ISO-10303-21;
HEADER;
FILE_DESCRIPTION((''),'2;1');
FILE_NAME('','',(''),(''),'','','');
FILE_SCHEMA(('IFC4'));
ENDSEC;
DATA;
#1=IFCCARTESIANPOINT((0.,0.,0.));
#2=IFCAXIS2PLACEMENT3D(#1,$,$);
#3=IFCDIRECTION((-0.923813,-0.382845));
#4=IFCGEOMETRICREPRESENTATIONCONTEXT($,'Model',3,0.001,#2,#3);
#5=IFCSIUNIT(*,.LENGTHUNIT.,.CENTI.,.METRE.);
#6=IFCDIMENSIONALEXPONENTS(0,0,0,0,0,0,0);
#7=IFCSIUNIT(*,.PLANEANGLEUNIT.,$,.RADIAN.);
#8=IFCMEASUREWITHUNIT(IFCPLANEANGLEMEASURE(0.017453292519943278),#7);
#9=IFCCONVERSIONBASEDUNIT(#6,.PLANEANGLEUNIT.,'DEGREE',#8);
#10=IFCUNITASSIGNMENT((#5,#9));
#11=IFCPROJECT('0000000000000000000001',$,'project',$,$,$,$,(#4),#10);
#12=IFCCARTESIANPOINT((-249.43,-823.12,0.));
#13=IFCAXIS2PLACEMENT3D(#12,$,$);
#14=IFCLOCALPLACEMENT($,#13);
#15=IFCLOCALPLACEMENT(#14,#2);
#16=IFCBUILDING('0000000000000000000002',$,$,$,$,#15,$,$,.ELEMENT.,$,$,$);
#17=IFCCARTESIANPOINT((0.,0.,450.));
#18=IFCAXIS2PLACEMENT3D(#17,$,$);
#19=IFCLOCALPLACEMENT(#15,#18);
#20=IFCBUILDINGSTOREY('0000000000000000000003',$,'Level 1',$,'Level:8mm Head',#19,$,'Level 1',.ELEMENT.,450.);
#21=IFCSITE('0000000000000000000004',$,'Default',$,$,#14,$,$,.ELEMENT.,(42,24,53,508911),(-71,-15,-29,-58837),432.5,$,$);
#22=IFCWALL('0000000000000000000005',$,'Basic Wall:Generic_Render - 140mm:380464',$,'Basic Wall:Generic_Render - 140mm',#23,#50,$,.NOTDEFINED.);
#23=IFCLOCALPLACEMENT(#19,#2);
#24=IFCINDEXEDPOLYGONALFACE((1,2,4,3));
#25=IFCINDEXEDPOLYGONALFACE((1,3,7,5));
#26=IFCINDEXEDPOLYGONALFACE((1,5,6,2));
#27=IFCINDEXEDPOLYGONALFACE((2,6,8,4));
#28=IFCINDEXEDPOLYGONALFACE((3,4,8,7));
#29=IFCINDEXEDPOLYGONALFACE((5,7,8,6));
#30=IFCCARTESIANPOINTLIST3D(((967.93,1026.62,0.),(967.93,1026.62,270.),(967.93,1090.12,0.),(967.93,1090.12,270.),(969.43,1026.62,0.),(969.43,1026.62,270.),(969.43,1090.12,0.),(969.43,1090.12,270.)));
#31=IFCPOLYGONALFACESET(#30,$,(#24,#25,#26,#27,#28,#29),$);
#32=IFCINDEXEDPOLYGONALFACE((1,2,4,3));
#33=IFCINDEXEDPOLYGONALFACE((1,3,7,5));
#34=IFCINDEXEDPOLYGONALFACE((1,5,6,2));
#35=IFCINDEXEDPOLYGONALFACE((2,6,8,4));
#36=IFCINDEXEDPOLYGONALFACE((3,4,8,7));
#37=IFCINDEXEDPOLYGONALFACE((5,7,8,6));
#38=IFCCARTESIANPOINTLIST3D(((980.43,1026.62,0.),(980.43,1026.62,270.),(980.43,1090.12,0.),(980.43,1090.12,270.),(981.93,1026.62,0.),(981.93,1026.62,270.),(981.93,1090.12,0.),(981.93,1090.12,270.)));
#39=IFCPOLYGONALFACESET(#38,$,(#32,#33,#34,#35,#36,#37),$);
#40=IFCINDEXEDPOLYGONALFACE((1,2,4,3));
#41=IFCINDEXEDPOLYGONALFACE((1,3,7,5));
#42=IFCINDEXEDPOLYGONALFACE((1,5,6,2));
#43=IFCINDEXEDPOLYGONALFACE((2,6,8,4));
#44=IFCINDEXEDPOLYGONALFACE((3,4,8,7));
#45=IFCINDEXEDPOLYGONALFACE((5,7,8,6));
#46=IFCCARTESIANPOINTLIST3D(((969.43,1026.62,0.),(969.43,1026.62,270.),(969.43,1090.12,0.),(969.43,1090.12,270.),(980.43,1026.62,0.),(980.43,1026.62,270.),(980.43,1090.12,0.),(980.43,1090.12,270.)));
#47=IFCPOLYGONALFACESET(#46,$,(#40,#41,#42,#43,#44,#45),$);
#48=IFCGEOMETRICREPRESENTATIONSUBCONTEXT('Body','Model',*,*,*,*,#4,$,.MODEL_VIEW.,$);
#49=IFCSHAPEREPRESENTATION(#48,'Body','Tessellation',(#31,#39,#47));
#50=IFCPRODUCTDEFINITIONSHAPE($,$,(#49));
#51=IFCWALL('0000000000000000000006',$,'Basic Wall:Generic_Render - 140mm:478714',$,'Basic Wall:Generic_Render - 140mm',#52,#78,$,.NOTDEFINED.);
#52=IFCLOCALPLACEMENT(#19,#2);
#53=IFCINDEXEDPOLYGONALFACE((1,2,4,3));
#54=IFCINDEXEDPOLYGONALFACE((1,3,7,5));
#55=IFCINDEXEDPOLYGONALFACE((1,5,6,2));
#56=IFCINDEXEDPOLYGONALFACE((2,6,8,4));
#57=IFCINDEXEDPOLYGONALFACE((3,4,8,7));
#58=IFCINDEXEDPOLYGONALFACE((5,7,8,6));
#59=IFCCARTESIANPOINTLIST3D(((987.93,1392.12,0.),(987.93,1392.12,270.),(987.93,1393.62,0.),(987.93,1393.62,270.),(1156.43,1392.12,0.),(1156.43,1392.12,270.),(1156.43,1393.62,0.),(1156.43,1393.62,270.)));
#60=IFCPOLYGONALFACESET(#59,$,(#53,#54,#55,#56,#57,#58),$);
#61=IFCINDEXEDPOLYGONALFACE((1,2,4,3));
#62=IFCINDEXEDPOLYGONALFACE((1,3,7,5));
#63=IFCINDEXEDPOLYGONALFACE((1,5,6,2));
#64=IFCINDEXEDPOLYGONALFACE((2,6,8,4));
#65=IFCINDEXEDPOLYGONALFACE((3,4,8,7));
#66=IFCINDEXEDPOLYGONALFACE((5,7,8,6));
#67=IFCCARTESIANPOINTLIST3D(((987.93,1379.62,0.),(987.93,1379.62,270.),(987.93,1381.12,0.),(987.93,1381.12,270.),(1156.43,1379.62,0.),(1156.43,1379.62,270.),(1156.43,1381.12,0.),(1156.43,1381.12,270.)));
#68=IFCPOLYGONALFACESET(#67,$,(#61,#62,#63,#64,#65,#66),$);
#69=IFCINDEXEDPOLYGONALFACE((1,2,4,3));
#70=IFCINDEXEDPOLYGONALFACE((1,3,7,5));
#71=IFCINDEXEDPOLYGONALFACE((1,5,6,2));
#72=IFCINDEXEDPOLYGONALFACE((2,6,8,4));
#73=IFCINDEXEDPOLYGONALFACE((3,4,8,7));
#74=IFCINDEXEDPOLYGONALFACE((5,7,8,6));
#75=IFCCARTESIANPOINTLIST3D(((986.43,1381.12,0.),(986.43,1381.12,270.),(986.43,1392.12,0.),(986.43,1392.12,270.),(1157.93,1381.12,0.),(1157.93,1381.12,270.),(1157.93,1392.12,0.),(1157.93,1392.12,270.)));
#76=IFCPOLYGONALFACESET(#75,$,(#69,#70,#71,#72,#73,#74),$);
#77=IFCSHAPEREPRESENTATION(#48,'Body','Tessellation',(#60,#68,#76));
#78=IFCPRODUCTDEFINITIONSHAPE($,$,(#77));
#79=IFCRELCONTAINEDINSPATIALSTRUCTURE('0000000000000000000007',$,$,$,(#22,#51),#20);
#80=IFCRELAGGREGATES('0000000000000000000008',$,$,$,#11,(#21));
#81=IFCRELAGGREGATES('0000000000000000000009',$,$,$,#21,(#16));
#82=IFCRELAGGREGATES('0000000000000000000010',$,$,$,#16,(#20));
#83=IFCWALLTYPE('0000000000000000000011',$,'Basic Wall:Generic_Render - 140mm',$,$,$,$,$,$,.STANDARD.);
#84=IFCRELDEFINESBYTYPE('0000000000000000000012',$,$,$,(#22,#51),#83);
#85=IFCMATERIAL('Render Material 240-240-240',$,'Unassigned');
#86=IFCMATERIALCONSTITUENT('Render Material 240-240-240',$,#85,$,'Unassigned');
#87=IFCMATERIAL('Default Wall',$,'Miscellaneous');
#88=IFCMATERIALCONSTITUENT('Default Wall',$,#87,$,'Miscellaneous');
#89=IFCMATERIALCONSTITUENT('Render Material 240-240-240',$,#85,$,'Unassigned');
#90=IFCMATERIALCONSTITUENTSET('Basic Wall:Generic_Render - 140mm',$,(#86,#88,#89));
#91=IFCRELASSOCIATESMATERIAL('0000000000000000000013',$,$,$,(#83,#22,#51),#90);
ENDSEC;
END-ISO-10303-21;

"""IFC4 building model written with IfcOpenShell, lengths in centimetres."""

from ifc_helpers import new_model, entity, si_unit, converted_unit, direction, frame, origin, place, context, subcontext, project, spatial, indexed_curve, outline, extrude, material, constituent, constituent_set, type_object, element, save


model = new_model("IFC4")

# Units and contexts
model_context = context("Model", 3, precision=0.001, world=origin(), true_north=direction((-0.923813, -0.382845)))
body_context = subcontext(model_context, "Body", "Model", "MODEL_VIEW")
ifc_project = project(units=[si_unit("LENGTHUNIT", "METRE", prefix="CENTI"), converted_unit("PLANEANGLEUNIT", "DEGREE", entity("IfcPlaneAngleMeasure", 0.017453292519943278), si_unit("PLANEANGLEUNIT", "RADIAN"), dimensions=[0, 0, 0, 0, 0, 0, 0])], contexts=[model_context])

# Site, building, storey
site_placement = place(None, frame((-249.43, -823.12, 0.0)))
site = spatial("IfcSite", under=ifc_project, at=site_placement, Name="Default", CompositionType="ELEMENT", RefLatitude=(42, 24, 53, 508911), RefLongitude=(-71, -15, -29, -58837), RefElevation=432.5)
building_placement = place(site_placement, origin())
building = spatial("IfcBuilding", under=site, at=building_placement, CompositionType="ELEMENT")
storey_placement = place(building_placement, frame((0.0, 0.0, 450.0)))
storey = spatial("IfcBuildingStorey", under=building, at=storey_placement, Name="Level 1", ObjectType="Level:8mm Head", LongName="Level 1", CompositionType="ELEMENT", Elevation=450.0)

# Walls
ifc_material_1 = material(Name="Render Material 240-240-240", Category="Unassigned")
ifc_material_2 = material(Name="Default Wall", Category="Miscellaneous")
ifc_constituent_1 = constituent(ifc_material_1, Name="Render Material 240-240-240", Category="Unassigned")
ifc_constituent_2 = constituent(ifc_material_2, Name="Default Wall", Category="Miscellaneous")
ifc_constituent_3 = constituent(ifc_material_1, Name="Render Material 240-240-240", Category="Unassigned")
ifc_constituent_set_1 = constituent_set(constituents=[ifc_constituent_1, ifc_constituent_2, ifc_constituent_3], Name="Basic Wall:Generic_Render - 140mm")
wall_type_1 = type_object("IfcWallType", Name="Basic Wall:Generic_Render - 140mm", PredefinedType="STANDARD", material=ifc_constituent_set_1)
wall_1_placement = place(storey_placement, frame((974.93, 1090.12, 0.0), z_axis=(0.0, 0.0, 1.0), x_axis=(0.0, -1.0, 0.0)))
element("IfcWall", 1, at=wall_1_placement, inside=storey, type_object=wall_type_1, material=ifc_constituent_set_1, Name="Basic Wall:Generic_Render - 140mm:380464", ObjectType="Basic Wall:Generic_Render - 140mm", PredefinedType="NOTDEFINED", context=body_context, shape_type="SweptSolid", body=[
    extrude(outline(indexed_curve([(-0.75, -31.75), (0.75, -31.75), (0.75, 31.75), (-0.75, 31.75), (-0.75, -31.75)], self_intersect=False)), frame((31.75, -6.25, 0.0), z_axis=(0.0, 0.0, 1.0), x_axis=(0.0, 1.0, 0.0)), (0.0, 0.0, 1.0), 270.0),
    extrude(outline(indexed_curve([(-0.75, -31.75), (0.75, -31.75), (0.75, 31.75), (-0.75, 31.75), (-0.75, -31.75)], self_intersect=False)), frame((31.75, 6.25, 0.0), z_axis=(0.0, 0.0, 1.0), x_axis=(0.0, -1.0, 0.0)), (0.0, 0.0, 1.0), 270.0),
    extrude(outline(indexed_curve([(-31.75, -5.5), (31.75, -5.5), (31.75, 5.5), (-31.75, 5.5), (-31.75, -5.5)], self_intersect=False)), frame((31.75, 0.0, 0.0)), (0.0, 0.0, 1.0), 270.0),
])
wall_2_placement = place(storey_placement, frame((1156.43, 1386.62, 0.0), z_axis=(0.0, 0.0, 1.0), x_axis=(-1.0, 0.0, 0.0)))
element("IfcWall", 2, at=wall_2_placement, inside=storey, type_object=wall_type_1, material=ifc_constituent_set_1, Name="Basic Wall:Generic_Render - 140mm:478714", ObjectType="Basic Wall:Generic_Render - 140mm", PredefinedType="NOTDEFINED", context=body_context, shape_type="SweptSolid", body=[
    extrude(outline(indexed_curve([(-0.75, -84.25), (0.75, -84.25), (0.75, 84.25), (-0.75, 84.25), (-0.75, -84.25)], self_intersect=False)), frame((84.25, -6.25, 0.0), z_axis=(0.0, 0.0, 1.0), x_axis=(0.0, 1.0, 0.0)), (0.0, 0.0, 1.0), 270.0),
    extrude(outline(indexed_curve([(-0.75, -84.25), (0.75, -84.25), (0.75, 84.25), (-0.75, 84.25), (-0.75, -84.25)], self_intersect=False)), frame((84.25, 6.25, 0.0), z_axis=(0.0, 0.0, 1.0), x_axis=(0.0, -1.0, 0.0)), (0.0, 0.0, 1.0), 270.0),
    extrude(outline(indexed_curve([(-85.75, -5.5), (85.75, -5.5), (85.75, 5.5), (-85.75, 5.5), (-85.75, -5.5)], self_intersect=False)), frame((84.25, 0.0, 0.0)), (0.0, 0.0, 1.0), 270.0),
])

save(model, "model.ifc")
